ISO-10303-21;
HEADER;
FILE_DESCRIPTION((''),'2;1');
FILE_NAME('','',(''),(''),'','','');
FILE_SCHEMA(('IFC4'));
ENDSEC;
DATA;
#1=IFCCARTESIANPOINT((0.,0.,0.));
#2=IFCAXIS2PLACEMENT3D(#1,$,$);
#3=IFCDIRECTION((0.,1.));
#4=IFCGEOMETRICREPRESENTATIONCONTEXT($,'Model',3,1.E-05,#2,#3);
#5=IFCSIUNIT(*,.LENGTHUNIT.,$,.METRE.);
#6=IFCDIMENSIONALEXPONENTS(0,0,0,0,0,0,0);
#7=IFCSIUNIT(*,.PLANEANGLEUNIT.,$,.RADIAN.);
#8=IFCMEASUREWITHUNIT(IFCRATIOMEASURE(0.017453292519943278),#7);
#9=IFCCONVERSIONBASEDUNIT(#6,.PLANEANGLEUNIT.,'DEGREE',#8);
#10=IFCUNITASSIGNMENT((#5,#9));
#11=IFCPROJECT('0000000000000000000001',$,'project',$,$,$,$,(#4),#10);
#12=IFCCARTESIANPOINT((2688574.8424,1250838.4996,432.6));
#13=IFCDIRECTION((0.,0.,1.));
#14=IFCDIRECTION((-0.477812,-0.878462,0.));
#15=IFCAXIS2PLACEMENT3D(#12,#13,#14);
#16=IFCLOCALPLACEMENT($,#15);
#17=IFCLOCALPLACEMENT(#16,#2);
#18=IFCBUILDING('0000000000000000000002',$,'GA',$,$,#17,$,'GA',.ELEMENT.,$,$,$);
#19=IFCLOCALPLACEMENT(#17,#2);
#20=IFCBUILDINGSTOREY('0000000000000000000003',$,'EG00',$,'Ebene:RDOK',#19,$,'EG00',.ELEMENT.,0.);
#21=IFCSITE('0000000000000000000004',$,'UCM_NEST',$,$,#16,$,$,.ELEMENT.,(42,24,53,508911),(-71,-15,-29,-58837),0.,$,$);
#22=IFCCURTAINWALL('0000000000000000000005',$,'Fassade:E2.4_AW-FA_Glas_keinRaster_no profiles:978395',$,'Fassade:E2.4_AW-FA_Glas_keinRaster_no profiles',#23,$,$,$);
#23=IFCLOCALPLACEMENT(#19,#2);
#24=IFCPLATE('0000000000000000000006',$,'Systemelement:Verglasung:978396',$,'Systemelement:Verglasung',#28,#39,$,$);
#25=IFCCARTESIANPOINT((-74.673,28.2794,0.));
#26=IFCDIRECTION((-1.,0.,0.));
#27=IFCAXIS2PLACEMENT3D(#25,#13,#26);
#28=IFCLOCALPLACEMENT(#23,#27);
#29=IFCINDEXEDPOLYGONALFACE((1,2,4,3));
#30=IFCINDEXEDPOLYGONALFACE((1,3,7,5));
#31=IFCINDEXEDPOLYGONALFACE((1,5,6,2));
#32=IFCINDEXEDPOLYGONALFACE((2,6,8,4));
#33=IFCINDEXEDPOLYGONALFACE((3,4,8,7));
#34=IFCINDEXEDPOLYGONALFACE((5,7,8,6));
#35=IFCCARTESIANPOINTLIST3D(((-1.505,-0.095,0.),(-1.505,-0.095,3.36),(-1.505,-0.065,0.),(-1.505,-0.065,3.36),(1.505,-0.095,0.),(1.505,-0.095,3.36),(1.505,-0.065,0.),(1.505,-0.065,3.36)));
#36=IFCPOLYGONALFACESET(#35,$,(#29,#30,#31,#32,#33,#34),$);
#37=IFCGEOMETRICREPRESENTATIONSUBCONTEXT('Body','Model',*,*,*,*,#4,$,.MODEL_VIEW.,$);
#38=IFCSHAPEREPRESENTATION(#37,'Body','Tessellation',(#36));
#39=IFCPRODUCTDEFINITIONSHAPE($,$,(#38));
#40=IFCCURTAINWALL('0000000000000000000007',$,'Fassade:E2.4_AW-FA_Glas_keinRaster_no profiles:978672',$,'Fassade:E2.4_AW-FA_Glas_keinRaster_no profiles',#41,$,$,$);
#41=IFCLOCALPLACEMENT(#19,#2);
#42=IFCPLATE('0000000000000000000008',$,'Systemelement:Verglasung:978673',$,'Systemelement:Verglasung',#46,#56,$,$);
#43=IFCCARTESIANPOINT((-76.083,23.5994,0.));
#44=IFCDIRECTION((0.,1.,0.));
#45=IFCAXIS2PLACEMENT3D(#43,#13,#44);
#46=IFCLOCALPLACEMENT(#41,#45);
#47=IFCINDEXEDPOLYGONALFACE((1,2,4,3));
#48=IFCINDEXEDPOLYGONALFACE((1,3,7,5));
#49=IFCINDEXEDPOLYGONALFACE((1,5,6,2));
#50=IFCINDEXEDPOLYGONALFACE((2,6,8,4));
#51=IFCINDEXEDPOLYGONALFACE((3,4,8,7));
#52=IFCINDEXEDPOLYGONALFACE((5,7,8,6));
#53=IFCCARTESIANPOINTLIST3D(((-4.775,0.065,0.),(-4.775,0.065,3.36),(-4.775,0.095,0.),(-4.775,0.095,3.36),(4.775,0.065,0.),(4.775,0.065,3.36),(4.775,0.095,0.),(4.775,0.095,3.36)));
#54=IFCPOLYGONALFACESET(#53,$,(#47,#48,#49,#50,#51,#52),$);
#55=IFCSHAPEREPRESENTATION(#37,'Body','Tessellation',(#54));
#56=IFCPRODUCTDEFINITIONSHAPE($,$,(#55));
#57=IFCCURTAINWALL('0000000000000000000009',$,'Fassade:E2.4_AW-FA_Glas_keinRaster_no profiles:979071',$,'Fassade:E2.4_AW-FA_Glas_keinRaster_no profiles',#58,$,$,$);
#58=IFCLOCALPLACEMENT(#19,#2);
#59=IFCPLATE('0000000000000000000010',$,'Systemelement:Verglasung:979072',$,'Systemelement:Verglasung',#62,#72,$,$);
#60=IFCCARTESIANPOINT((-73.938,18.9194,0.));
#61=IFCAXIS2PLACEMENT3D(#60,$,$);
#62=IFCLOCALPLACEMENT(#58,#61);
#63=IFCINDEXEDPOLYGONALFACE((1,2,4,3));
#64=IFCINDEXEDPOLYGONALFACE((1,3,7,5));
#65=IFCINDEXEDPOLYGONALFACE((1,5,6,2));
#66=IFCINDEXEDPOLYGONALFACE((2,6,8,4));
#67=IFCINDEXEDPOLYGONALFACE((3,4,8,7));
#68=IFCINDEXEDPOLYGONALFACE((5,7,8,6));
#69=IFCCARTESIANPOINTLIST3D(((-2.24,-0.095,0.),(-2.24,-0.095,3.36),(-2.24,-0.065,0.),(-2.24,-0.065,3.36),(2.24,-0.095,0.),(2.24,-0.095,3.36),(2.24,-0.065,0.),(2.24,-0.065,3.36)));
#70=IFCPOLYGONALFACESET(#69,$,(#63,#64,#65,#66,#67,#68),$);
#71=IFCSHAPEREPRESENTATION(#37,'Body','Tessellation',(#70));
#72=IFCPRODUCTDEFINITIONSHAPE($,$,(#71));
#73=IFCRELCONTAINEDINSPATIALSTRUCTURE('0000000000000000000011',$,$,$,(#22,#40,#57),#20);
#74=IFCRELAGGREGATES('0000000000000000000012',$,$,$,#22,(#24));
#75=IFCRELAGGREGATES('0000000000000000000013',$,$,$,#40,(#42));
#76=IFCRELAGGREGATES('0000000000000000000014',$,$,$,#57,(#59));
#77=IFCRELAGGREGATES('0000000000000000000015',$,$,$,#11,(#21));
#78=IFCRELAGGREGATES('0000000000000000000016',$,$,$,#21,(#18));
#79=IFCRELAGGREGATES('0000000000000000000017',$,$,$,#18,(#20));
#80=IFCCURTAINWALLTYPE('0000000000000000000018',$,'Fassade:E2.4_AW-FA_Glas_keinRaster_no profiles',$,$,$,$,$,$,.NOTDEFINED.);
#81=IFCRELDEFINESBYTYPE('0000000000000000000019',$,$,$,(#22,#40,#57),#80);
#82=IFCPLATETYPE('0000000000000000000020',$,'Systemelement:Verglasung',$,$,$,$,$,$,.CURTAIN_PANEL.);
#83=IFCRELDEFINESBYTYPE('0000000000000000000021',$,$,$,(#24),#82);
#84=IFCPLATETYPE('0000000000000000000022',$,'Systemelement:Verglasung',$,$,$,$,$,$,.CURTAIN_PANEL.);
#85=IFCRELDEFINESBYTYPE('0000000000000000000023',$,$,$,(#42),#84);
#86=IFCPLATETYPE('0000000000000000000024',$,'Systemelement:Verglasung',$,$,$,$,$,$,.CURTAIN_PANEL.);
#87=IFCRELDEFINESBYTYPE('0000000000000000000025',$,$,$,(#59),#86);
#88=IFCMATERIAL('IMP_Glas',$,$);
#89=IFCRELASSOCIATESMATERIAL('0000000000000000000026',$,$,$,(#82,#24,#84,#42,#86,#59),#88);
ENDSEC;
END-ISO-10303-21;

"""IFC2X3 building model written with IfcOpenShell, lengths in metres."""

from ifc_helpers import new_model, entity, si_unit, converted_unit, direction, frame, frame_2d, origin, place, context, subcontext, project, spatial, rectangle, extrude, source, transform, mapped, material, type_object, type_shapes, element, aggregate, save


model = new_model("IFC2X3")

# Units and contexts
model_context = context("Model", 3, precision=1e-05, world=origin(), true_north=direction((0.0, 1.0)))
body_context = subcontext(model_context, "Body", "Model", "MODEL_VIEW")
ifc_project = project(units=[si_unit("LENGTHUNIT", "METRE"), converted_unit("PLANEANGLEUNIT", "DEGREE", entity("IfcRatioMeasure", 0.017453292519943278), si_unit("PLANEANGLEUNIT", "RADIAN"), dimensions=[0, 0, 0, 0, 0, 0, 0])], contexts=[model_context])

# Site, building, storey
site_placement = place(None, frame((2688574.8424, 1250838.4996, 432.6), z_axis=(0.0, 0.0, 1.0), x_axis=(-0.477812, -0.878462, 0.0)))
site = spatial("IfcSite", under=ifc_project, at=site_placement, Name="UCM_NEST", CompositionType="ELEMENT", RefLatitude=(42, 24, 53, 508911), RefLongitude=(-71, -15, -29, -58837), RefElevation=0.0)
building_placement = place(site_placement, origin())
building = spatial("IfcBuilding", under=site, at=building_placement, Name="GA", LongName="GA", CompositionType="ELEMENT")
storey_placement = place(building_placement, origin())
storey = spatial("IfcBuildingStorey", under=building, at=storey_placement, Name="EG00", ObjectType="Ebene:RDOK", LongName="EG00", CompositionType="ELEMENT", Elevation=0.0)

# Curtain walls, plates
curtain_wall_type = type_object("IfcCurtainWallType", Name="Fassade:E2.4_AW-FA_Glas_keinRaster_no profiles", PredefinedType="NOTDEFINED")
curtain_wall_1_placement = place(storey_placement, origin())
curtain_wall_1 = element("IfcCurtainWall", 1, at=curtain_wall_1_placement, inside=storey, type_object=curtain_wall_type, Name="Fassade:E2.4_AW-FA_Glas_keinRaster_no profiles:978395", ObjectType="Fassade:E2.4_AW-FA_Glas_keinRaster_no profiles")
ifc_material_1 = material(Name="IMP_Glas")
plate_type_1 = type_object("IfcPlateType", Name="Systemelement:Verglasung", PredefinedType="CURTAIN_PANEL", material=ifc_material_1)
shared_shape_1 = source(origin(), body_context, "Body", "SweptSolid", [
    extrude(rectangle(XDim=0.03, YDim=3.01, at=frame_2d((0.0, 0.0), x_axis=(1.0, 0.0))), frame((0.0, -0.08, 0.0), z_axis=(0.0, 0.0, 1.0), x_axis=(0.0, 1.0, 0.0)), (0.0, 0.0, 1.0), 3.36),
])
type_shapes(plate_type_1, [shared_shape_1])
plate_1_placement = place(curtain_wall_1_placement, frame((-74.673, 28.2794, 0.0), z_axis=(0.0, 0.0, 1.0), x_axis=(-1.0, 0.0, 0.0)))
plate_1 = element("IfcPlate", 2, at=plate_1_placement, type_object=plate_type_1, material=ifc_material_1, Name="Systemelement:Verglasung:978396", ObjectType="Systemelement:Verglasung", context=body_context, shape_type="MappedRepresentation", body=[
    mapped(shared_shape_1, transform((0.0, 0.0, 0.0), scale=1.0)),
])
aggregate(curtain_wall_1, [plate_1])
curtain_wall_2_placement = place(storey_placement, origin())
curtain_wall_2 = element("IfcCurtainWall", 3, at=curtain_wall_2_placement, inside=storey, type_object=curtain_wall_type, Name="Fassade:E2.4_AW-FA_Glas_keinRaster_no profiles:978672", ObjectType="Fassade:E2.4_AW-FA_Glas_keinRaster_no profiles")
plate_type_2 = type_object("IfcPlateType", Name="Systemelement:Verglasung", PredefinedType="CURTAIN_PANEL", material=ifc_material_1)
shared_shape_2 = source(origin(), body_context, "Body", "SweptSolid", [
    extrude(rectangle(XDim=0.03, YDim=9.55, at=frame_2d((0.0, 0.0), x_axis=(1.0, 0.0))), frame((0.0, 0.08, 0.0), z_axis=(0.0, 0.0, 1.0), x_axis=(0.0, 1.0, 0.0)), (0.0, 0.0, 1.0), 3.36),
])
type_shapes(plate_type_2, [shared_shape_2])
plate_2_placement = place(curtain_wall_2_placement, frame((-76.083, 23.5994, 0.0), z_axis=(0.0, 0.0, 1.0), x_axis=(0.0, 1.0, 0.0)))
plate_2 = element("IfcPlate", 4, at=plate_2_placement, type_object=plate_type_2, material=ifc_material_1, Name="Systemelement:Verglasung:978673", ObjectType="Systemelement:Verglasung", context=body_context, shape_type="MappedRepresentation", body=[
    mapped(shared_shape_2, transform((0.0, 0.0, 0.0), scale=1.0)),
])
aggregate(curtain_wall_2, [plate_2])
curtain_wall_3_placement = place(storey_placement, origin())
curtain_wall_3 = element("IfcCurtainWall", 5, at=curtain_wall_3_placement, inside=storey, type_object=curtain_wall_type, Name="Fassade:E2.4_AW-FA_Glas_keinRaster_no profiles:979071", ObjectType="Fassade:E2.4_AW-FA_Glas_keinRaster_no profiles")
plate_type_3 = type_object("IfcPlateType", Name="Systemelement:Verglasung", PredefinedType="CURTAIN_PANEL", material=ifc_material_1)
shared_shape_3 = source(origin(), body_context, "Body", "SweptSolid", [
    extrude(rectangle(XDim=0.03, YDim=4.48, at=frame_2d((0.0, 0.0), x_axis=(1.0, 0.0))), frame((0.0, -0.08, 0.0), z_axis=(0.0, 0.0, 1.0), x_axis=(0.0, 1.0, 0.0)), (0.0, 0.0, 1.0), 3.36),
])
type_shapes(plate_type_3, [shared_shape_3])
plate_3_placement = place(curtain_wall_3_placement, frame((-73.938, 18.9194, 0.0)))
plate_3 = element("IfcPlate", 6, at=plate_3_placement, type_object=plate_type_3, material=ifc_material_1, Name="Systemelement:Verglasung:979072", ObjectType="Systemelement:Verglasung", context=body_context, shape_type="MappedRepresentation", body=[
    mapped(shared_shape_3, transform((0.0, 0.0, 0.0), scale=1.0)),
])
aggregate(curtain_wall_3, [plate_3])

save(model, "model.ifc")
